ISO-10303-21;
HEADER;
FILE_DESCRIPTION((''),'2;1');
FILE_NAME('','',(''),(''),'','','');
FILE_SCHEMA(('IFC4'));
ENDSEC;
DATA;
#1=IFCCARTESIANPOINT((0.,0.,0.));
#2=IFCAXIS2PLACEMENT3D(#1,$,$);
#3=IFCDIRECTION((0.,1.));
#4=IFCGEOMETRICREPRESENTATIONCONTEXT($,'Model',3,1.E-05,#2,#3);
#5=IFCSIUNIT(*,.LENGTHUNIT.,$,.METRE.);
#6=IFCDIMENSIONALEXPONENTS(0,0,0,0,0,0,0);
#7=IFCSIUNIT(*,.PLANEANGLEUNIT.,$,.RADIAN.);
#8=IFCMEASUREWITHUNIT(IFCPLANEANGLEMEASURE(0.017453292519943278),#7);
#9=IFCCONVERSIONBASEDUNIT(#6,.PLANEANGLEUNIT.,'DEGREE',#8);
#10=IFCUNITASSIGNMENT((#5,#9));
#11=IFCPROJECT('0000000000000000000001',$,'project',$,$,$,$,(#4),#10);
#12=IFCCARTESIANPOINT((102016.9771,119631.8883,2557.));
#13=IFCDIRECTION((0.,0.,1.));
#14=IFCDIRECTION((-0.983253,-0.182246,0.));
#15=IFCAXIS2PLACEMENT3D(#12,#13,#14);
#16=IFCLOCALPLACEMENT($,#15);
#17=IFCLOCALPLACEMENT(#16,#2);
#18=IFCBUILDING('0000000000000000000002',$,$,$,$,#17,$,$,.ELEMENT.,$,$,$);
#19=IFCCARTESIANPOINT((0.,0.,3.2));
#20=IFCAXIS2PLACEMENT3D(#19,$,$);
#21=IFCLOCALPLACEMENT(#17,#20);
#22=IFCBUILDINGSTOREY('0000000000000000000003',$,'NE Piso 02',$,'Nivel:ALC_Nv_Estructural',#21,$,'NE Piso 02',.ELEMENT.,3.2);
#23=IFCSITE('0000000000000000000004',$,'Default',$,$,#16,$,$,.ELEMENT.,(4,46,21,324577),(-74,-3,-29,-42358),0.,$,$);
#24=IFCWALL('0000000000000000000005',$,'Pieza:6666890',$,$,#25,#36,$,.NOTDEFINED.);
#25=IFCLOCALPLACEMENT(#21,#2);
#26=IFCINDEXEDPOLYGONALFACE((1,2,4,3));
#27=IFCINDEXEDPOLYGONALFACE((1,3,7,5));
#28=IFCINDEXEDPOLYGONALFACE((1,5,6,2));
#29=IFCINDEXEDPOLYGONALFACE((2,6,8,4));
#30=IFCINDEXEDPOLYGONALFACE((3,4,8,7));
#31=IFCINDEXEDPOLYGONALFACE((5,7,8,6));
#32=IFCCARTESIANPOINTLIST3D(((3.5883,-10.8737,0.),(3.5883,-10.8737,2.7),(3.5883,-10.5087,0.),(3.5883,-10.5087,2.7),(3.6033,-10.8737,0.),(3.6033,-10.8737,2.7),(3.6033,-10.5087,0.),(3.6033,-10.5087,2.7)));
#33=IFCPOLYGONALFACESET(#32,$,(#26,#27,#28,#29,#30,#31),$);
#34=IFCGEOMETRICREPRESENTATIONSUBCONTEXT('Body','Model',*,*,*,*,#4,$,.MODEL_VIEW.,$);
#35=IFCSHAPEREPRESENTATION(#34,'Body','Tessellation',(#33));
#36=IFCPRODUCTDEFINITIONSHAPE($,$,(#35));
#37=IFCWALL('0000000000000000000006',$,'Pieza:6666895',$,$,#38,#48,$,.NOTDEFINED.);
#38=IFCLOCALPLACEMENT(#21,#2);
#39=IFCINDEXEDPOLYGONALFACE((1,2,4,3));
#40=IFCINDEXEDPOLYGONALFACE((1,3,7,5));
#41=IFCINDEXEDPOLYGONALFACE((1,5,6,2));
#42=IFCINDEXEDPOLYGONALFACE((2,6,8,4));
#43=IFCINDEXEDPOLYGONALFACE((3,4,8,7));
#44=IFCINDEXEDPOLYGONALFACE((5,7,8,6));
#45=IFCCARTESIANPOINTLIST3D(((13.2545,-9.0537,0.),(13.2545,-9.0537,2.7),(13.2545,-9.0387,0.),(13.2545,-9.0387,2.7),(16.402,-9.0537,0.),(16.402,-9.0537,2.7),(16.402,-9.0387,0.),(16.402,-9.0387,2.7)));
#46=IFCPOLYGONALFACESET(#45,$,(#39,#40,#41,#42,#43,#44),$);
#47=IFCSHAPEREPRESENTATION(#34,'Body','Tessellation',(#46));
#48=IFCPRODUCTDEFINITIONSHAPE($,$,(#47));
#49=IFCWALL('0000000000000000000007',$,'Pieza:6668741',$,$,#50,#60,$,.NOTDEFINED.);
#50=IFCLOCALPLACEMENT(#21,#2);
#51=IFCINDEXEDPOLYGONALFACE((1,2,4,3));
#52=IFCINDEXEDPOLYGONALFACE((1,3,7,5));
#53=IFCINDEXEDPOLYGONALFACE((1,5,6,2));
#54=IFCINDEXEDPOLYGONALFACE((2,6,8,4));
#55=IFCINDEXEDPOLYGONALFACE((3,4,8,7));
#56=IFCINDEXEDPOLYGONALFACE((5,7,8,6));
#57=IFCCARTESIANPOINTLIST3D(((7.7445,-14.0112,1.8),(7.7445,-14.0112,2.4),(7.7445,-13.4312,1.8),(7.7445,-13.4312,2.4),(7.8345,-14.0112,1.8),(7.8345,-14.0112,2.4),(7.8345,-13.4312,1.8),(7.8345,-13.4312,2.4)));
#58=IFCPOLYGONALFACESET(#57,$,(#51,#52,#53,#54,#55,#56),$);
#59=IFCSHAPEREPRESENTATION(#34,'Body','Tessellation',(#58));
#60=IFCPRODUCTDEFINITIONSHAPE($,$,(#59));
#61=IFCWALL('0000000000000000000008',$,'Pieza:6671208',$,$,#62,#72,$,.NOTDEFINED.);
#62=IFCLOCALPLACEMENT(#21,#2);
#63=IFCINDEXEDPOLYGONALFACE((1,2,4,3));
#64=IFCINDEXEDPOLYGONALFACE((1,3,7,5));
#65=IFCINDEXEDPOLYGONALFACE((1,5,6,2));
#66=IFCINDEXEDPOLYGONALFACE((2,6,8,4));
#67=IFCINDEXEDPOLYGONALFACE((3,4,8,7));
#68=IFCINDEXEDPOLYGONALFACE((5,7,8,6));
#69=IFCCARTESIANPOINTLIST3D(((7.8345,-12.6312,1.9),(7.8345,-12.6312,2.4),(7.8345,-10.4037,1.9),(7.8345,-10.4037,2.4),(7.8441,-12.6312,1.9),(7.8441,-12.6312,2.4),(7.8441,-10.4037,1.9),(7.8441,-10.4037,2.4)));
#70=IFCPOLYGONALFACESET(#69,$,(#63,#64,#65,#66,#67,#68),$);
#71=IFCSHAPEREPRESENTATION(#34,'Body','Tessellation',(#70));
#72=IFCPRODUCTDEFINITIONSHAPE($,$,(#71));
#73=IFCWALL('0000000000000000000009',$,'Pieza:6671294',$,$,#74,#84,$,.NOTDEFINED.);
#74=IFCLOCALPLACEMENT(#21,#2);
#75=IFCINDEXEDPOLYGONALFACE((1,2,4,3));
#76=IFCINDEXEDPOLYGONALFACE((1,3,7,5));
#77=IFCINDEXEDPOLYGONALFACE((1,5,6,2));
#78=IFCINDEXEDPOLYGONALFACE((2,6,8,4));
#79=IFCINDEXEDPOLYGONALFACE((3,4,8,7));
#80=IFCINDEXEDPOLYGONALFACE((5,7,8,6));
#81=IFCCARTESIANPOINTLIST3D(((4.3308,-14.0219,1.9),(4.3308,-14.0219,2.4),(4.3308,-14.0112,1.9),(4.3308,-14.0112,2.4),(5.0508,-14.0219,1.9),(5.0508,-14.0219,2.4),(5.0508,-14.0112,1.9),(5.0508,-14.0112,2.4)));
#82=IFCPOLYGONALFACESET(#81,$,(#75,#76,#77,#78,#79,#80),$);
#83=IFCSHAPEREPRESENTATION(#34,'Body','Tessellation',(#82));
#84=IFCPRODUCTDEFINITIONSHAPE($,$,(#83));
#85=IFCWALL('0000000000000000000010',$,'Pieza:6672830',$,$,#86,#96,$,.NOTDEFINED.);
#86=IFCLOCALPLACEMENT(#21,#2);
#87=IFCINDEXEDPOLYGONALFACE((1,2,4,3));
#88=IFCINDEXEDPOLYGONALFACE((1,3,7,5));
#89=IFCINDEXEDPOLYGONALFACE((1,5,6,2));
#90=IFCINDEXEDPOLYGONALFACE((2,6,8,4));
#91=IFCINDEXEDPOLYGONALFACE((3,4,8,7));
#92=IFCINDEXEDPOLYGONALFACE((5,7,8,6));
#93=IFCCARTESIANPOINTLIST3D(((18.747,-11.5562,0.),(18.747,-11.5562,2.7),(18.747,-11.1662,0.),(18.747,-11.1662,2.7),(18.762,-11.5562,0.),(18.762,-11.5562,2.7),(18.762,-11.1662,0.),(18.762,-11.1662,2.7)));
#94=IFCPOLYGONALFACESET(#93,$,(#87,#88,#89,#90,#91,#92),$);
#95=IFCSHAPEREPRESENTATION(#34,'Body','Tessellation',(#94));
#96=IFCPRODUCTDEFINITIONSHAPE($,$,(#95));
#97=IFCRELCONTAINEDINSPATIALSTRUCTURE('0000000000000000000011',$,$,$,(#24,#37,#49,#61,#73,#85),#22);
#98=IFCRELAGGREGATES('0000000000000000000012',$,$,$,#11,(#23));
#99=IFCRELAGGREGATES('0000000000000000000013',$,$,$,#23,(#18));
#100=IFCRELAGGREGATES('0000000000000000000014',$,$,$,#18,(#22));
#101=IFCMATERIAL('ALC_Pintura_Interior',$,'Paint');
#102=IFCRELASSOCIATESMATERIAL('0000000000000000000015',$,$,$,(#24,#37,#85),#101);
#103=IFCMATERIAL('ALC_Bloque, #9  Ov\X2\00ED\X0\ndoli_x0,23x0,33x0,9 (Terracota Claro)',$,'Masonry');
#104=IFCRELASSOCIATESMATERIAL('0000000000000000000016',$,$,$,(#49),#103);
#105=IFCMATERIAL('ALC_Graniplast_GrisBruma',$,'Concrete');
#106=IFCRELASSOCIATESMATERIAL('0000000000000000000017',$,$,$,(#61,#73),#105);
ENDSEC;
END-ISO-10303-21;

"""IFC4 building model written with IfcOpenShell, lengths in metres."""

from ifc_helpers import new_model, entity, si_unit, converted_unit, direction, frame, frame_2d, origin, place, context, subcontext, project, spatial, rectangle, extrude, material, element, save


model = new_model("IFC4")

# Units and contexts
model_context = context("Model", 3, precision=1e-05, world=origin(), true_north=direction((0.0, 1.0)))
body_context = subcontext(model_context, "Body", "Model", "MODEL_VIEW")
ifc_project = project(units=[si_unit("LENGTHUNIT", "METRE"), converted_unit("PLANEANGLEUNIT", "DEGREE", entity("IfcPlaneAngleMeasure", 0.017453292519943278), si_unit("PLANEANGLEUNIT", "RADIAN"), dimensions=[0, 0, 0, 0, 0, 0, 0])], contexts=[model_context])

# Site, building, storey
site_placement = place(None, frame((102016.9771, 119631.8883, 2557.0), z_axis=(0.0, 0.0, 1.0), x_axis=(-0.983253, -0.182246, 0.0)))
site = spatial("IfcSite", under=ifc_project, at=site_placement, Name="Default", CompositionType="ELEMENT", RefLatitude=(4, 46, 21, 324577), RefLongitude=(-74, -3, -29, -42358), RefElevation=0.0)
building_placement = place(site_placement, origin())
building = spatial("IfcBuilding", under=site, at=building_placement, CompositionType="ELEMENT")
storey_placement = place(building_placement, frame((0.0, 0.0, 3.2)))
storey = spatial("IfcBuildingStorey", under=building, at=storey_placement, Name="NE Piso 02", ObjectType="Nivel:ALC_Nv_Estructural", LongName="NE Piso 02", CompositionType="ELEMENT", Elevation=3.2)

# Walls
ifc_material_1 = material(Name="ALC_Bloque, #9  Ovíndoli_x0,23x0,33x0,9 (Terracota Claro)", Category="Masonry")
ifc_material_2 = material(Name="ALC_Pintura_Interior", Category="Paint")
wall_1_placement = place(storey_placement, origin())
element("IfcWall", 1, at=wall_1_placement, inside=storey, material=ifc_material_2, Name="Pieza:6666890", PredefinedType="NOTDEFINED", context=body_context, shape_type="SweptSolid", body=[
    extrude(rectangle(XDim=0.365, YDim=0.015, at=frame_2d((0.0, 0.0), x_axis=(1.0, 0.0))), frame((3.5958, -10.6912, 0.0), z_axis=(0.0, 0.0, 1.0), x_axis=(0.0, -1.0, 0.0)), (0.0, 0.0, 1.0), 2.7),
])
wall_2_placement = place(storey_placement, origin())
element("IfcWall", 2, at=wall_2_placement, inside=storey, material=ifc_material_2, Name="Pieza:6666895", PredefinedType="NOTDEFINED", context=body_context, shape_type="SweptSolid", body=[
    extrude(rectangle(XDim=0.015, YDim=3.1475, at=frame_2d((0.0, 0.0), x_axis=(1.0, 0.0))), frame((14.8283, -9.0462, 0.0), z_axis=(0.0, 0.0, 1.0), x_axis=(0.0, -1.0, 0.0)), (0.0, 0.0, 1.0), 2.7),
])
wall_3_placement = place(storey_placement, frame((0.0, 0.0, 1.8)))
element("IfcWall", 3, at=wall_3_placement, inside=storey, material=ifc_material_1, Name="Pieza:6668741", PredefinedType="NOTDEFINED", context=body_context, shape_type="SweptSolid", body=[
    extrude(rectangle(XDim=0.58, YDim=0.09, at=frame_2d((0.0, 0.0), x_axis=(1.0, 0.0))), frame((7.7895, -13.7212, 0.0), z_axis=(0.0, 0.0, 1.0), x_axis=(0.0, -1.0, 0.0)), (0.0, 0.0, 1.0), 0.6),
])
ifc_material_3 = material(Name="ALC_Graniplast_GrisBruma", Category="Concrete")
wall_4_placement = place(storey_placement, frame((0.0, 0.0, 1.9)))
element("IfcWall", 4, at=wall_4_placement, inside=storey, material=ifc_material_3, Name="Pieza:6671208", PredefinedType="NOTDEFINED", context=body_context, shape_type="SweptSolid", body=[
    extrude(rectangle(XDim=2.2275, YDim=0.0096, at=frame_2d((0.0, 0.0), x_axis=(1.0, 0.0))), frame((7.8393, -11.5174, 0.0), z_axis=(0.0, 0.0, 1.0), x_axis=(0.0, -1.0, 0.0)), (0.0, 0.0, 1.0), 0.5),
])
wall_5_placement = place(storey_placement, frame((0.0, 0.0, 1.9)))
element("IfcWall", 5, at=wall_5_placement, inside=storey, material=ifc_material_3, Name="Pieza:6671294", PredefinedType="NOTDEFINED", context=body_context, shape_type="SweptSolid", body=[
    extrude(rectangle(XDim=0.0108, YDim=0.72, at=frame_2d((0.0, 0.0), x_axis=(1.0, 0.0))), frame((4.6908, -14.0166, 0.0), z_axis=(0.0, 0.0, 1.0), x_axis=(0.0, -1.0, 0.0)), (0.0, 0.0, 1.0), 0.5),
])
wall_6_placement = place(storey_placement, origin())
element("IfcWall", 6, at=wall_6_placement, inside=storey, material=ifc_material_2, Name="Pieza:6672830", PredefinedType="NOTDEFINED", context=body_context, shape_type="SweptSolid", body=[
    extrude(rectangle(XDim=0.39, YDim=0.015, at=frame_2d((0.0, 0.0), x_axis=(1.0, 0.0))), frame((18.7545, -11.3612, 0.0), z_axis=(0.0, 0.0, 1.0), x_axis=(0.0, -1.0, 0.0)), (0.0, 0.0, 1.0), 2.7),
])

save(model, "model.ifc")
